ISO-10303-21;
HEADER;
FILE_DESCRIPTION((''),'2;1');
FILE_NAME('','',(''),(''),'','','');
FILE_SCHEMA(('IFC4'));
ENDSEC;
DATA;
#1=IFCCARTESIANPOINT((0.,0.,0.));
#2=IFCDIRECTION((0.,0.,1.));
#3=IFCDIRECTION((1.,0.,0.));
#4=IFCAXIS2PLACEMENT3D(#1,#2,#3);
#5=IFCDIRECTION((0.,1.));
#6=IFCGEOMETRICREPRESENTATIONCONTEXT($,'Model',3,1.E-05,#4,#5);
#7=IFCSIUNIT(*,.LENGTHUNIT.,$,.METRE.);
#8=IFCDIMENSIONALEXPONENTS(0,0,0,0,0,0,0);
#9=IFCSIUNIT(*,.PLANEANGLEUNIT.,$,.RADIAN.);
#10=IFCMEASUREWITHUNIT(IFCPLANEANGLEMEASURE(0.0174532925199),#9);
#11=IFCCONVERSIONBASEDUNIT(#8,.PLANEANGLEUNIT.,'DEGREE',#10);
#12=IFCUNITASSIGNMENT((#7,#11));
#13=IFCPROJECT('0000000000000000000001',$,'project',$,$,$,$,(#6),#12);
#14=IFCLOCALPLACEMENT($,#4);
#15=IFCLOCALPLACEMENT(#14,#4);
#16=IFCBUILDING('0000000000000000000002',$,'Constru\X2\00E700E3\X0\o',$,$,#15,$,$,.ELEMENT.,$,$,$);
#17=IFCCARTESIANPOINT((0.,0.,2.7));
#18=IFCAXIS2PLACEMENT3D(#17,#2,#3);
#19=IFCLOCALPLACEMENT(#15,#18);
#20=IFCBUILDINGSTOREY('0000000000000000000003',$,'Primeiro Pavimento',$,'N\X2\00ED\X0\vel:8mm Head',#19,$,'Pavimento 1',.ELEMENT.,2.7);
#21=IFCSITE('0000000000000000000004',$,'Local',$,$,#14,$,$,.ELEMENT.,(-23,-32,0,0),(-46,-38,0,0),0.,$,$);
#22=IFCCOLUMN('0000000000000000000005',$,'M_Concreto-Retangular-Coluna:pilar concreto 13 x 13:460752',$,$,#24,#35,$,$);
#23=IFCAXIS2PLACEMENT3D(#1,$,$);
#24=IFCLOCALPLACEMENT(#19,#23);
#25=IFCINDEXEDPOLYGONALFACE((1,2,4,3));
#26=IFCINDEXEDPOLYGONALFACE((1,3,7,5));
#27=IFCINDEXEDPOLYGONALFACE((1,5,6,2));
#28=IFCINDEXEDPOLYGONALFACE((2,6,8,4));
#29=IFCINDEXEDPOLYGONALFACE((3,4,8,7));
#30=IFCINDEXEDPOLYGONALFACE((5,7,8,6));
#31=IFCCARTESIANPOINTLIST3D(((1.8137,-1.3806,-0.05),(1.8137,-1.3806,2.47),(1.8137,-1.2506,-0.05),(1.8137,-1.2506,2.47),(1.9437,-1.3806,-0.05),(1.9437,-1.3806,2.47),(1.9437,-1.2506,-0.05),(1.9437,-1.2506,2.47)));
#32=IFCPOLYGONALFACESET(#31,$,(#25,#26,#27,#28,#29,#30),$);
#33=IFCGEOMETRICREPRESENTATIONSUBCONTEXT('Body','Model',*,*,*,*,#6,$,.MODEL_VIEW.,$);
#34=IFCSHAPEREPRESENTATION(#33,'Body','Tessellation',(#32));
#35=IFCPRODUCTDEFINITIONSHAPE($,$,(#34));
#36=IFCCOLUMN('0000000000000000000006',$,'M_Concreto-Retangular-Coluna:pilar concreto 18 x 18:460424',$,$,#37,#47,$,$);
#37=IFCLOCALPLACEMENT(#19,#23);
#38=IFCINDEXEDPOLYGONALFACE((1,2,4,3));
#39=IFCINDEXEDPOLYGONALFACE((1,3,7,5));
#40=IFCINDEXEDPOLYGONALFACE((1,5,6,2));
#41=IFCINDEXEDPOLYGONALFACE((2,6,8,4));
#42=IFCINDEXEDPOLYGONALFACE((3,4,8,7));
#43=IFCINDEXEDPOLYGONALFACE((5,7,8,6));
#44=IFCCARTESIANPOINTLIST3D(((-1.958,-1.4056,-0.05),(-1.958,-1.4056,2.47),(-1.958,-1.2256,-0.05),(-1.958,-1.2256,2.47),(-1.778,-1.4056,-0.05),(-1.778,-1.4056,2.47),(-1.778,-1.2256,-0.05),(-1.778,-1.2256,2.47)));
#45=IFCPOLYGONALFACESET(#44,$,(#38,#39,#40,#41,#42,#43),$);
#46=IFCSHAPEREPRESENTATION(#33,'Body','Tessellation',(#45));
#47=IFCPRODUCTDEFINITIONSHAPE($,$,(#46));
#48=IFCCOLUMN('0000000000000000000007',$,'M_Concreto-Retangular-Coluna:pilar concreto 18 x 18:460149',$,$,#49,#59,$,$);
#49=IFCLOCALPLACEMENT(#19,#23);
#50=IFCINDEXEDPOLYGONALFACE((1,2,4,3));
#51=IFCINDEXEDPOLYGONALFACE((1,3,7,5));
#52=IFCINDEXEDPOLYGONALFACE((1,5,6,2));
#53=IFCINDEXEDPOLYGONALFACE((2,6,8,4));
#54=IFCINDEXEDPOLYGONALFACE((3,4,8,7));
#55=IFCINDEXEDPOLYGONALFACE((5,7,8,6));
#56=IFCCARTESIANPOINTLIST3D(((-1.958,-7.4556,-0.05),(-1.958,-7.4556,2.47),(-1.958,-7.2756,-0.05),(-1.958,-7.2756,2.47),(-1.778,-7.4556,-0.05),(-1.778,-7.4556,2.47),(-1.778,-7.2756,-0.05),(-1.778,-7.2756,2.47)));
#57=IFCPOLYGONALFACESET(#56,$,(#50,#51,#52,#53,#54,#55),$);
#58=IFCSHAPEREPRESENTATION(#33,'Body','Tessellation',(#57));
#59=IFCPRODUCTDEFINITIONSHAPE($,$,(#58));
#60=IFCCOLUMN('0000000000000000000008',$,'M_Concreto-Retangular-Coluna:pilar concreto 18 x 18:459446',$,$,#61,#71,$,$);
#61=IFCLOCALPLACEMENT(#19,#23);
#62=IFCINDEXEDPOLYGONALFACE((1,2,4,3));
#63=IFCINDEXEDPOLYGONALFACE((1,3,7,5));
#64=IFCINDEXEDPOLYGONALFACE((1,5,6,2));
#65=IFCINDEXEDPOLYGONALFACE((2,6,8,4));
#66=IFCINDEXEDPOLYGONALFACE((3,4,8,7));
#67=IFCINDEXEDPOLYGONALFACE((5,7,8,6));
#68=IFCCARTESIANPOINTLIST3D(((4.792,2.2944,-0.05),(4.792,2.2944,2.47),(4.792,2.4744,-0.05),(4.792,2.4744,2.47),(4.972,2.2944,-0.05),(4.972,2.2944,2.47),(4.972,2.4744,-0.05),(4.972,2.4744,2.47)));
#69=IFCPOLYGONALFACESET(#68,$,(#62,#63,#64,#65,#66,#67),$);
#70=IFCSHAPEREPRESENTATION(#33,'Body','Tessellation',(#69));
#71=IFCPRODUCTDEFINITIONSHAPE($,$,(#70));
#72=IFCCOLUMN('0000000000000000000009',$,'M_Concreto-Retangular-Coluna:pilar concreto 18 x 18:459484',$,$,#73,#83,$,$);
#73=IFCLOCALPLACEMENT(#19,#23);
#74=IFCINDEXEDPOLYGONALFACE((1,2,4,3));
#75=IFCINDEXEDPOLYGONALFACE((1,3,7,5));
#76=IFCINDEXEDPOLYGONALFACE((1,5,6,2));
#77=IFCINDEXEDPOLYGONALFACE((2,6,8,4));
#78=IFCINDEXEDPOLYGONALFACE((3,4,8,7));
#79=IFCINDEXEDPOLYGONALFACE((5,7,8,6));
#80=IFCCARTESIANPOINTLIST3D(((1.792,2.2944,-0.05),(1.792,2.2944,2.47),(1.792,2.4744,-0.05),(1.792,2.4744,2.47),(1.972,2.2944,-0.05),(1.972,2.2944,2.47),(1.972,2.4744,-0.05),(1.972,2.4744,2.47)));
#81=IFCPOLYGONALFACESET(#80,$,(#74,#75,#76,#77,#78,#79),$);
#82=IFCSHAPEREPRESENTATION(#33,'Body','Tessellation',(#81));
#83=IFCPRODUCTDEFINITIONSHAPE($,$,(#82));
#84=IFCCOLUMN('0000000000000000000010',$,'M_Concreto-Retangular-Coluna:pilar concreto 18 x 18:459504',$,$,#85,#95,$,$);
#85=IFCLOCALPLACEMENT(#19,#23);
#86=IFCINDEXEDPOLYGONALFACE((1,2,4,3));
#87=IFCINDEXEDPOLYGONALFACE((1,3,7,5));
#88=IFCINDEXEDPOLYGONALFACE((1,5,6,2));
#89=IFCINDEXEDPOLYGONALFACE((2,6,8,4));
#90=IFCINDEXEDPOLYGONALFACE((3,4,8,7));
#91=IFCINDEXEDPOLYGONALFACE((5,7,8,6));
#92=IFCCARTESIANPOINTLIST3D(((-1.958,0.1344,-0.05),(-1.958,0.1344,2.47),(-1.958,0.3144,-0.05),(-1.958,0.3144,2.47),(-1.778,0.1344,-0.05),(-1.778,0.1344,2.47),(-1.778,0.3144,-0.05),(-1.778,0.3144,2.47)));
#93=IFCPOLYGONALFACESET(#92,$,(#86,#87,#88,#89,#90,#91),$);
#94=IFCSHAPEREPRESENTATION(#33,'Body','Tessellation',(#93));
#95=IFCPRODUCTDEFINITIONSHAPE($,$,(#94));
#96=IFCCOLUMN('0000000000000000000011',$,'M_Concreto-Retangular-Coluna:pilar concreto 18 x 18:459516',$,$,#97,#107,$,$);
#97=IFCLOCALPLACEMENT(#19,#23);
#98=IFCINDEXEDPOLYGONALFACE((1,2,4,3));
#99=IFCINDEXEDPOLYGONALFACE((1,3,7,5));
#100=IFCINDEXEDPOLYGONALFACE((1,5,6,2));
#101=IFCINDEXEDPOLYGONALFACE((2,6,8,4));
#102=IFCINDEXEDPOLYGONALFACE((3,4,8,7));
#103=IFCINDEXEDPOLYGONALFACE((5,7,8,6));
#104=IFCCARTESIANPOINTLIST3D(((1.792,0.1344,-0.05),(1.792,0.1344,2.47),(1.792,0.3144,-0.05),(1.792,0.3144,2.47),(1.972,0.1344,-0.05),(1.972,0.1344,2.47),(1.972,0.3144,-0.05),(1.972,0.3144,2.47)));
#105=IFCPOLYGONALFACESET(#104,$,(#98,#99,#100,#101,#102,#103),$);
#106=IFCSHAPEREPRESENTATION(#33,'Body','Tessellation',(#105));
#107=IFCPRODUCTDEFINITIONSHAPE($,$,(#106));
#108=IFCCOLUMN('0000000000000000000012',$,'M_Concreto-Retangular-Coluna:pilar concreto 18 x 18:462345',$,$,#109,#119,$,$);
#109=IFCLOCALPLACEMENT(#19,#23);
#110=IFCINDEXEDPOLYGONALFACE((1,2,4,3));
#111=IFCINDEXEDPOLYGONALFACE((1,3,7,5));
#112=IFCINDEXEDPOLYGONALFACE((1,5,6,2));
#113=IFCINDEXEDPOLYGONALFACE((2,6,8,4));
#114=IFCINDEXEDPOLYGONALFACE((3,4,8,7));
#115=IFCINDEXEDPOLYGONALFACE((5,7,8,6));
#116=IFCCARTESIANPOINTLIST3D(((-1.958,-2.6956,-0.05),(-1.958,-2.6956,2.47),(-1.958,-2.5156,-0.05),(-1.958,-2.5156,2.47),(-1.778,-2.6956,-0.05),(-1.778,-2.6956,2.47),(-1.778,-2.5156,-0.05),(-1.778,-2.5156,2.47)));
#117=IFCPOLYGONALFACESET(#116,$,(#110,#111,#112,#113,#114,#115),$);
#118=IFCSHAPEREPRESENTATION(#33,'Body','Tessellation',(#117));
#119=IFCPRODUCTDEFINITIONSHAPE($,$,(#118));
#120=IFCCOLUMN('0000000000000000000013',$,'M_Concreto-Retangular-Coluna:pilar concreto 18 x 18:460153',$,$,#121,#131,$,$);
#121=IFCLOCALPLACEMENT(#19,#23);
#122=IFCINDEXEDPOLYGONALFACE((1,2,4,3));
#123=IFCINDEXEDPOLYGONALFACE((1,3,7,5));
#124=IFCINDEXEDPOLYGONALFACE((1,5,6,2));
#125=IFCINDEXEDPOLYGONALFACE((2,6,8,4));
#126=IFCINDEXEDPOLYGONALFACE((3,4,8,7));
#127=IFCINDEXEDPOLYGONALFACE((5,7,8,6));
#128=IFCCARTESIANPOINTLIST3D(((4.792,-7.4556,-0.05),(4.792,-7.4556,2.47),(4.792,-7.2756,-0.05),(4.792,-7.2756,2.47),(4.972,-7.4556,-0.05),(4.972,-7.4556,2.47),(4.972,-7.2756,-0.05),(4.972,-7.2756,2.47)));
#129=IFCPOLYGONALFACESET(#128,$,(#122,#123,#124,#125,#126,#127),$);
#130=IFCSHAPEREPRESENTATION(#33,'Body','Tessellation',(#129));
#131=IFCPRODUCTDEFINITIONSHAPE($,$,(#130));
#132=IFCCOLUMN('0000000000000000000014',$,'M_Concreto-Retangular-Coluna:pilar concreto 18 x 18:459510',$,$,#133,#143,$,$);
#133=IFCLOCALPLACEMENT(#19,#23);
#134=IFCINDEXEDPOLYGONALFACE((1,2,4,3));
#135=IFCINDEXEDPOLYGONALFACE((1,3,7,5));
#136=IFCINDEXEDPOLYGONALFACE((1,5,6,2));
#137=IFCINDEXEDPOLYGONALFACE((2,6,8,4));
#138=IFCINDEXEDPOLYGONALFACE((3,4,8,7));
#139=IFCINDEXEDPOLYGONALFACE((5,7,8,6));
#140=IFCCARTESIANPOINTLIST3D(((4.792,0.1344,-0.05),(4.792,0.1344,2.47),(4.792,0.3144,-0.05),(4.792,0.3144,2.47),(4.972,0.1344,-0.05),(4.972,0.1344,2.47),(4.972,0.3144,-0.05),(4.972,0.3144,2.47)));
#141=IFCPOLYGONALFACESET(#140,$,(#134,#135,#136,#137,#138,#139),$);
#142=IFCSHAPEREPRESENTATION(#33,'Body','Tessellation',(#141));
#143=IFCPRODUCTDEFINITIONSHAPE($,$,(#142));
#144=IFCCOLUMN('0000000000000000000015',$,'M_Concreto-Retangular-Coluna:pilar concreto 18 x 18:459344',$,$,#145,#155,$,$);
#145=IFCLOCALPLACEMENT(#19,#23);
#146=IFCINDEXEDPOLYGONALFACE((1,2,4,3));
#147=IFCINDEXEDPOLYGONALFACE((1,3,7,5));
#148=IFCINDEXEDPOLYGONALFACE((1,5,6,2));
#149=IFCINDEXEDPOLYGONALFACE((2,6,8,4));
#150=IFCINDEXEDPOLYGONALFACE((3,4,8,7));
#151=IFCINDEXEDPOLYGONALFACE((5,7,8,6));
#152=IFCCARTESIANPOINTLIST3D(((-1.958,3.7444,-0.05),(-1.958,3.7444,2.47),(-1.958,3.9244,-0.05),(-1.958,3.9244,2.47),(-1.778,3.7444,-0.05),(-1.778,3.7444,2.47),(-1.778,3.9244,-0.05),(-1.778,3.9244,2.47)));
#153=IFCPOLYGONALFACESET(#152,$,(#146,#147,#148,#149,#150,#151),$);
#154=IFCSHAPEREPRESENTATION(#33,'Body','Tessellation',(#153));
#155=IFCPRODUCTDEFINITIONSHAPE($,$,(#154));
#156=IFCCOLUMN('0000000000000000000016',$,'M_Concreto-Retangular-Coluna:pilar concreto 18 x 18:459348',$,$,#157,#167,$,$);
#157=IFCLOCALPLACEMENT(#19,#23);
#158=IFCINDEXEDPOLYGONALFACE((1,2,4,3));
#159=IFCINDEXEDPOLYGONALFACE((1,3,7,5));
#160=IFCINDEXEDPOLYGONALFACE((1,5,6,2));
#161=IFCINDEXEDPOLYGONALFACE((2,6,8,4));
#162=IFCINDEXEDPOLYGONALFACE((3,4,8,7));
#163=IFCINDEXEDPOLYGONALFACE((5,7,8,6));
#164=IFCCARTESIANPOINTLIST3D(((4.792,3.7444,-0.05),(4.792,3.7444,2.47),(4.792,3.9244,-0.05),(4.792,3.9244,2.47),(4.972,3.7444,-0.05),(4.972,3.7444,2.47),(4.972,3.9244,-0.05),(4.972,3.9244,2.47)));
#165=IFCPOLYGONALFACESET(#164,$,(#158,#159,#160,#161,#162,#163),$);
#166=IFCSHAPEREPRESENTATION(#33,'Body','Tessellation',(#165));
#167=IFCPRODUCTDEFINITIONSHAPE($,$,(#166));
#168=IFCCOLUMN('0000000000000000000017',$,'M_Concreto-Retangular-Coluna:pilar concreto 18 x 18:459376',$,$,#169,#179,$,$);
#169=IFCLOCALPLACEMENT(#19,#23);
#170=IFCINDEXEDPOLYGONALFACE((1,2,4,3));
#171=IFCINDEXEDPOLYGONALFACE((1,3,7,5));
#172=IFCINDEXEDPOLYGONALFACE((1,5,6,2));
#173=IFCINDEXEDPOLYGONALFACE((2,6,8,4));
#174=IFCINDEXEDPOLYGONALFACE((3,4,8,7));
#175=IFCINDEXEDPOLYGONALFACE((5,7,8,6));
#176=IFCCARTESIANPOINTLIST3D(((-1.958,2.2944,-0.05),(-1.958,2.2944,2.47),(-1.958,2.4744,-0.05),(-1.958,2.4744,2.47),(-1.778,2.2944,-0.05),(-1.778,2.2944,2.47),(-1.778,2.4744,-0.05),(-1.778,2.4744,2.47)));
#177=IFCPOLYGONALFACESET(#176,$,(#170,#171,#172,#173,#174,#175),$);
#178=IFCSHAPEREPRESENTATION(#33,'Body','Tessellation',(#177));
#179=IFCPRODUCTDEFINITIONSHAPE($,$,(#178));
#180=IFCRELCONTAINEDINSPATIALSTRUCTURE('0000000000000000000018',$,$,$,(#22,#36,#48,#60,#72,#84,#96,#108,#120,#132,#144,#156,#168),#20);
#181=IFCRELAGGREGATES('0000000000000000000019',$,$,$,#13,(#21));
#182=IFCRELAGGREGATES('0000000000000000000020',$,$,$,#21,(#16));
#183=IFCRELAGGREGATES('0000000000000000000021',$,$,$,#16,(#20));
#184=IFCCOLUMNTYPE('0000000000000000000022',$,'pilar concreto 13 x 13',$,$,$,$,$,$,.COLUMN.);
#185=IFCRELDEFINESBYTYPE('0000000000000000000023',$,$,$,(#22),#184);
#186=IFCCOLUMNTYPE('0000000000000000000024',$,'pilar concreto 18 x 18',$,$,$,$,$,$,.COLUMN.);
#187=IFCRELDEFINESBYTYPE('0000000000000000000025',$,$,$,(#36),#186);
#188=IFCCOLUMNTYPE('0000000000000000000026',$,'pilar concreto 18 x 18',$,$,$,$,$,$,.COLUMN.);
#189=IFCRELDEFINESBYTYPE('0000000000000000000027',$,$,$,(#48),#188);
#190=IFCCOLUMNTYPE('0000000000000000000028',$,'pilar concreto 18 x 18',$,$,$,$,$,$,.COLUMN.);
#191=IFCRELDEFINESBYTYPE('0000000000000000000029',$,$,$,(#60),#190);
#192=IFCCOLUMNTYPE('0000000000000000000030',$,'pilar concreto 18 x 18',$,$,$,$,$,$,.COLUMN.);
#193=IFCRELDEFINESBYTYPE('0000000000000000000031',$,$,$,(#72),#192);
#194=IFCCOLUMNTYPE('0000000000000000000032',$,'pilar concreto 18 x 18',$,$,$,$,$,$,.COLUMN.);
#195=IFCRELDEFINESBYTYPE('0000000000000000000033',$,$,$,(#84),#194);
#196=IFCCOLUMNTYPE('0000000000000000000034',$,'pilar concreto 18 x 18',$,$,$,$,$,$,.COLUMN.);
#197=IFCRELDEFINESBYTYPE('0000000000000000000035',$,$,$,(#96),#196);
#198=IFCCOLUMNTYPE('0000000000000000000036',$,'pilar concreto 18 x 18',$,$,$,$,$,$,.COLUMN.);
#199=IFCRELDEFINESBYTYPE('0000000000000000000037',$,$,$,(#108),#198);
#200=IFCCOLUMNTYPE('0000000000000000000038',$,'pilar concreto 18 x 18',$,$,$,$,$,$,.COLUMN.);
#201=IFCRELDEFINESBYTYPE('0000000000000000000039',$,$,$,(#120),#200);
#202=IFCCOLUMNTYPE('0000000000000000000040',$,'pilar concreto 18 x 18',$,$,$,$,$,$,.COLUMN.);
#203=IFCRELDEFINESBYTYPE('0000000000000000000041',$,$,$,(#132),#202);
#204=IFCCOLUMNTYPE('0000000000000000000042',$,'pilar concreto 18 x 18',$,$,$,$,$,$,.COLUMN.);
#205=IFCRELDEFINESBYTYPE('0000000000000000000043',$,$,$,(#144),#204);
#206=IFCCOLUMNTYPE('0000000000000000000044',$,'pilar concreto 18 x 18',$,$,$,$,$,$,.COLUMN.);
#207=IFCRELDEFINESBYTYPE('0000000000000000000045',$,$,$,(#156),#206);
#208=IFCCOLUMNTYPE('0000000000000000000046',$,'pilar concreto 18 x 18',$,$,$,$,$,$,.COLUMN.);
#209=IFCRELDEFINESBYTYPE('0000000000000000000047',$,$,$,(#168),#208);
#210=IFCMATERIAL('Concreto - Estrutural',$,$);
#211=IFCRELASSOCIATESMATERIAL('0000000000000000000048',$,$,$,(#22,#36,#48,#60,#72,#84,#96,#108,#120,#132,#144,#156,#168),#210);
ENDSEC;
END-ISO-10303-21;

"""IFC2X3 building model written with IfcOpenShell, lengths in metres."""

from ifc_helpers import new_model, entity, si_unit, converted_unit, direction, frame, origin_with_axes, origin_2d_with_axis, place, context, subcontext, project, spatial, rectangle, extrude, material, type_object, element, save


model = new_model("IFC2X3")

# Units and contexts
model_context = context("Model", 3, precision=1e-05, world=origin_with_axes(), true_north=direction((0.0, 1.0)))
body_context = subcontext(model_context, "Body", "Model", "MODEL_VIEW")
ifc_project = project(units=[si_unit("LENGTHUNIT", "METRE"), converted_unit("PLANEANGLEUNIT", "DEGREE", entity("IfcPlaneAngleMeasure", 0.0174532925199), si_unit("PLANEANGLEUNIT", "RADIAN"), dimensions=[0, 0, 0, 0, 0, 0, 0])], contexts=[model_context])

# Site, building, storey
site_placement = place(None, origin_with_axes())
site = spatial("IfcSite", under=ifc_project, at=site_placement, Name="Local", CompositionType="ELEMENT", RefLatitude=(-23, -32, 0, 0), RefLongitude=(-46, -38, 0, 0), RefElevation=0.0)
building_placement = place(site_placement, origin_with_axes())
building = spatial("IfcBuilding", under=site, at=building_placement, Name="Construção", CompositionType="ELEMENT")
storey_placement = place(building_placement, frame((0.0, 0.0, 2.7), z_axis=(0.0, 0.0, 1.0), x_axis=(1.0, 0.0, 0.0)))
storey = spatial("IfcBuildingStorey", under=building, at=storey_placement, Name="Primeiro Pavimento", ObjectType="Nível:8mm Head", LongName="Pavimento 1", CompositionType="ELEMENT", Elevation=2.7)

# Columns
ifc_material = material(Name="Concreto - Estrutural")
column_type_1 = type_object("IfcColumnType", Name="pilar concreto 13 x 13", PredefinedType="COLUMN")
column_1_placement = place(storey_placement, frame((1.8787, -1.3156, -0.05), z_axis=(0.0, 0.0, 1.0), x_axis=(0.0, -1.0, 0.0)))
element("IfcColumn", 1, at=column_1_placement, inside=storey, type_object=column_type_1, material=ifc_material, Name="M_Concreto-Retangular-Coluna:pilar concreto 13 x 13:460752", context=body_context, shape_type="SweptSolid", body=[
    extrude(rectangle(XDim=0.13, YDim=0.13, at=origin_2d_with_axis()), origin_with_axes(), (0.0, 0.0, 1.0), 2.52),
])
column_type_2 = type_object("IfcColumnType", Name="pilar concreto 18 x 18", PredefinedType="COLUMN")
column_2_placement = place(storey_placement, frame((-1.868, -1.3156, -0.05), z_axis=(0.0, 0.0, 1.0), x_axis=(0.0, -1.0, 0.0)))
element("IfcColumn", 2, at=column_2_placement, inside=storey, type_object=column_type_2, material=ifc_material, Name="M_Concreto-Retangular-Coluna:pilar concreto 18 x 18:460424", context=body_context, shape_type="SweptSolid", body=[
    extrude(rectangle(XDim=0.18, YDim=0.18, at=origin_2d_with_axis()), origin_with_axes(), (0.0, 0.0, 1.0), 2.52),
])
column_type_3 = type_object("IfcColumnType", Name="pilar concreto 18 x 18", PredefinedType="COLUMN")
column_3_placement = place(storey_placement, frame((-1.868, -7.3656, -0.05), z_axis=(0.0, 0.0, 1.0), x_axis=(0.0, -1.0, 0.0)))
element("IfcColumn", 3, at=column_3_placement, inside=storey, type_object=column_type_3, material=ifc_material, Name="M_Concreto-Retangular-Coluna:pilar concreto 18 x 18:460149", context=body_context, shape_type="SweptSolid", body=[
    extrude(rectangle(XDim=0.18, YDim=0.18, at=origin_2d_with_axis()), origin_with_axes(), (0.0, 0.0, 1.0), 2.52),
])
column_type_4 = type_object("IfcColumnType", Name="pilar concreto 18 x 18", PredefinedType="COLUMN")
column_4_placement = place(storey_placement, frame((4.882, 2.3844, -0.05), z_axis=(0.0, 0.0, 1.0), x_axis=(0.0, -1.0, 0.0)))
element("IfcColumn", 4, at=column_4_placement, inside=storey, type_object=column_type_4, material=ifc_material, Name="M_Concreto-Retangular-Coluna:pilar concreto 18 x 18:459446", context=body_context, shape_type="SweptSolid", body=[
    extrude(rectangle(XDim=0.18, YDim=0.18, at=origin_2d_with_axis()), origin_with_axes(), (0.0, 0.0, 1.0), 2.52),
])
column_type_5 = type_object("IfcColumnType", Name="pilar concreto 18 x 18", PredefinedType="COLUMN")
column_5_placement = place(storey_placement, frame((1.882, 2.3844, -0.05), z_axis=(0.0, 0.0, 1.0), x_axis=(0.0, -1.0, 0.0)))
element("IfcColumn", 5, at=column_5_placement, inside=storey, type_object=column_type_5, material=ifc_material, Name="M_Concreto-Retangular-Coluna:pilar concreto 18 x 18:459484", context=body_context, shape_type="SweptSolid", body=[
    extrude(rectangle(XDim=0.18, YDim=0.18, at=origin_2d_with_axis()), origin_with_axes(), (0.0, 0.0, 1.0), 2.52),
])
column_type_6 = type_object("IfcColumnType", Name="pilar concreto 18 x 18", PredefinedType="COLUMN")
column_6_placement = place(storey_placement, frame((-1.868, 0.2244, -0.05), z_axis=(0.0, 0.0, 1.0), x_axis=(0.0, -1.0, 0.0)))
element("IfcColumn", 6, at=column_6_placement, inside=storey, type_object=column_type_6, material=ifc_material, Name="M_Concreto-Retangular-Coluna:pilar concreto 18 x 18:459504", context=body_context, shape_type="SweptSolid", body=[
    extrude(rectangle(XDim=0.18, YDim=0.18, at=origin_2d_with_axis()), origin_with_axes(), (0.0, 0.0, 1.0), 2.52),
])
column_type_7 = type_object("IfcColumnType", Name="pilar concreto 18 x 18", PredefinedType="COLUMN")
column_7_placement = place(storey_placement, frame((1.882, 0.2244, -0.05), z_axis=(0.0, 0.0, 1.0), x_axis=(0.0, -1.0, 0.0)))
element("IfcColumn", 7, at=column_7_placement, inside=storey, type_object=column_type_7, material=ifc_material, Name="M_Concreto-Retangular-Coluna:pilar concreto 18 x 18:459516", context=body_context, shape_type="SweptSolid", body=[
    extrude(rectangle(XDim=0.18, YDim=0.18, at=origin_2d_with_axis()), origin_with_axes(), (0.0, 0.0, 1.0), 2.52),
])
column_type_8 = type_object("IfcColumnType", Name="pilar concreto 18 x 18", PredefinedType="COLUMN")
column_8_placement = place(storey_placement, frame((-1.868, -2.6056, -0.05), z_axis=(0.0, 0.0, 1.0), x_axis=(0.0, -1.0, 0.0)))
element("IfcColumn", 8, at=column_8_placement, inside=storey, type_object=column_type_8, material=ifc_material, Name="M_Concreto-Retangular-Coluna:pilar concreto 18 x 18:462345", context=body_context, shape_type="SweptSolid", body=[
    extrude(rectangle(XDim=0.18, YDim=0.18, at=origin_2d_with_axis()), origin_with_axes(), (0.0, 0.0, 1.0), 2.52),
])
column_type_9 = type_object("IfcColumnType", Name="pilar concreto 18 x 18", PredefinedType="COLUMN")
column_9_placement = place(storey_placement, frame((4.882, -7.3656, -0.05), z_axis=(0.0, 0.0, 1.0), x_axis=(0.0, -1.0, 0.0)))
element("IfcColumn", 9, at=column_9_placement, inside=storey, type_object=column_type_9, material=ifc_material, Name="M_Concreto-Retangular-Coluna:pilar concreto 18 x 18:460153", context=body_context, shape_type="SweptSolid", body=[
    extrude(rectangle(XDim=0.18, YDim=0.18, at=origin_2d_with_axis()), origin_with_axes(), (0.0, 0.0, 1.0), 2.52),
])
column_type_10 = type_object("IfcColumnType", Name="pilar concreto 18 x 18", PredefinedType="COLUMN")
column_10_placement = place(storey_placement, frame((4.882, 0.2244, -0.05), z_axis=(0.0, 0.0, 1.0), x_axis=(0.0, -1.0, 0.0)))
element("IfcColumn", 10, at=column_10_placement, inside=storey, type_object=column_type_10, material=ifc_material, Name="M_Concreto-Retangular-Coluna:pilar concreto 18 x 18:459510", context=body_context, shape_type="SweptSolid", body=[
    extrude(rectangle(XDim=0.18, YDim=0.18, at=origin_2d_with_axis()), origin_with_axes(), (0.0, 0.0, 1.0), 2.52),
])
column_type_11 = type_object("IfcColumnType", Name="pilar concreto 18 x 18", PredefinedType="COLUMN")
column_11_placement = place(storey_placement, frame((-1.868, 3.8344, -0.05), z_axis=(0.0, 0.0, 1.0), x_axis=(0.0, -1.0, 0.0)))
element("IfcColumn", 11, at=column_11_placement, inside=storey, type_object=column_type_11, material=ifc_material, Name="M_Concreto-Retangular-Coluna:pilar concreto 18 x 18:459344", context=body_context, shape_type="SweptSolid", body=[
    extrude(rectangle(XDim=0.18, YDim=0.18, at=origin_2d_with_axis()), origin_with_axes(), (0.0, 0.0, 1.0), 2.52),
])
column_type_12 = type_object("IfcColumnType", Name="pilar concreto 18 x 18", PredefinedType="COLUMN")
column_12_placement = place(storey_placement, frame((4.882, 3.8344, -0.05), z_axis=(0.0, 0.0, 1.0), x_axis=(0.0, -1.0, 0.0)))
element("IfcColumn", 12, at=column_12_placement, inside=storey, type_object=column_type_12, material=ifc_material, Name="M_Concreto-Retangular-Coluna:pilar concreto 18 x 18:459348", context=body_context, shape_type="SweptSolid", body=[
    extrude(rectangle(XDim=0.18, YDim=0.18, at=origin_2d_with_axis()), origin_with_axes(), (0.0, 0.0, 1.0), 2.52),
])
column_type_13 = type_object("IfcColumnType", Name="pilar concreto 18 x 18", PredefinedType="COLUMN")
column_13_placement = place(storey_placement, frame((-1.868, 2.3844, -0.05), z_axis=(0.0, 0.0, 1.0), x_axis=(0.0, -1.0, 0.0)))
element("IfcColumn", 13, at=column_13_placement, inside=storey, type_object=column_type_13, material=ifc_material, Name="M_Concreto-Retangular-Coluna:pilar concreto 18 x 18:459376", context=body_context, shape_type="SweptSolid", body=[
    extrude(rectangle(XDim=0.18, YDim=0.18, at=origin_2d_with_axis()), origin_with_axes(), (0.0, 0.0, 1.0), 2.52),
])

save(model, "model.ifc")
